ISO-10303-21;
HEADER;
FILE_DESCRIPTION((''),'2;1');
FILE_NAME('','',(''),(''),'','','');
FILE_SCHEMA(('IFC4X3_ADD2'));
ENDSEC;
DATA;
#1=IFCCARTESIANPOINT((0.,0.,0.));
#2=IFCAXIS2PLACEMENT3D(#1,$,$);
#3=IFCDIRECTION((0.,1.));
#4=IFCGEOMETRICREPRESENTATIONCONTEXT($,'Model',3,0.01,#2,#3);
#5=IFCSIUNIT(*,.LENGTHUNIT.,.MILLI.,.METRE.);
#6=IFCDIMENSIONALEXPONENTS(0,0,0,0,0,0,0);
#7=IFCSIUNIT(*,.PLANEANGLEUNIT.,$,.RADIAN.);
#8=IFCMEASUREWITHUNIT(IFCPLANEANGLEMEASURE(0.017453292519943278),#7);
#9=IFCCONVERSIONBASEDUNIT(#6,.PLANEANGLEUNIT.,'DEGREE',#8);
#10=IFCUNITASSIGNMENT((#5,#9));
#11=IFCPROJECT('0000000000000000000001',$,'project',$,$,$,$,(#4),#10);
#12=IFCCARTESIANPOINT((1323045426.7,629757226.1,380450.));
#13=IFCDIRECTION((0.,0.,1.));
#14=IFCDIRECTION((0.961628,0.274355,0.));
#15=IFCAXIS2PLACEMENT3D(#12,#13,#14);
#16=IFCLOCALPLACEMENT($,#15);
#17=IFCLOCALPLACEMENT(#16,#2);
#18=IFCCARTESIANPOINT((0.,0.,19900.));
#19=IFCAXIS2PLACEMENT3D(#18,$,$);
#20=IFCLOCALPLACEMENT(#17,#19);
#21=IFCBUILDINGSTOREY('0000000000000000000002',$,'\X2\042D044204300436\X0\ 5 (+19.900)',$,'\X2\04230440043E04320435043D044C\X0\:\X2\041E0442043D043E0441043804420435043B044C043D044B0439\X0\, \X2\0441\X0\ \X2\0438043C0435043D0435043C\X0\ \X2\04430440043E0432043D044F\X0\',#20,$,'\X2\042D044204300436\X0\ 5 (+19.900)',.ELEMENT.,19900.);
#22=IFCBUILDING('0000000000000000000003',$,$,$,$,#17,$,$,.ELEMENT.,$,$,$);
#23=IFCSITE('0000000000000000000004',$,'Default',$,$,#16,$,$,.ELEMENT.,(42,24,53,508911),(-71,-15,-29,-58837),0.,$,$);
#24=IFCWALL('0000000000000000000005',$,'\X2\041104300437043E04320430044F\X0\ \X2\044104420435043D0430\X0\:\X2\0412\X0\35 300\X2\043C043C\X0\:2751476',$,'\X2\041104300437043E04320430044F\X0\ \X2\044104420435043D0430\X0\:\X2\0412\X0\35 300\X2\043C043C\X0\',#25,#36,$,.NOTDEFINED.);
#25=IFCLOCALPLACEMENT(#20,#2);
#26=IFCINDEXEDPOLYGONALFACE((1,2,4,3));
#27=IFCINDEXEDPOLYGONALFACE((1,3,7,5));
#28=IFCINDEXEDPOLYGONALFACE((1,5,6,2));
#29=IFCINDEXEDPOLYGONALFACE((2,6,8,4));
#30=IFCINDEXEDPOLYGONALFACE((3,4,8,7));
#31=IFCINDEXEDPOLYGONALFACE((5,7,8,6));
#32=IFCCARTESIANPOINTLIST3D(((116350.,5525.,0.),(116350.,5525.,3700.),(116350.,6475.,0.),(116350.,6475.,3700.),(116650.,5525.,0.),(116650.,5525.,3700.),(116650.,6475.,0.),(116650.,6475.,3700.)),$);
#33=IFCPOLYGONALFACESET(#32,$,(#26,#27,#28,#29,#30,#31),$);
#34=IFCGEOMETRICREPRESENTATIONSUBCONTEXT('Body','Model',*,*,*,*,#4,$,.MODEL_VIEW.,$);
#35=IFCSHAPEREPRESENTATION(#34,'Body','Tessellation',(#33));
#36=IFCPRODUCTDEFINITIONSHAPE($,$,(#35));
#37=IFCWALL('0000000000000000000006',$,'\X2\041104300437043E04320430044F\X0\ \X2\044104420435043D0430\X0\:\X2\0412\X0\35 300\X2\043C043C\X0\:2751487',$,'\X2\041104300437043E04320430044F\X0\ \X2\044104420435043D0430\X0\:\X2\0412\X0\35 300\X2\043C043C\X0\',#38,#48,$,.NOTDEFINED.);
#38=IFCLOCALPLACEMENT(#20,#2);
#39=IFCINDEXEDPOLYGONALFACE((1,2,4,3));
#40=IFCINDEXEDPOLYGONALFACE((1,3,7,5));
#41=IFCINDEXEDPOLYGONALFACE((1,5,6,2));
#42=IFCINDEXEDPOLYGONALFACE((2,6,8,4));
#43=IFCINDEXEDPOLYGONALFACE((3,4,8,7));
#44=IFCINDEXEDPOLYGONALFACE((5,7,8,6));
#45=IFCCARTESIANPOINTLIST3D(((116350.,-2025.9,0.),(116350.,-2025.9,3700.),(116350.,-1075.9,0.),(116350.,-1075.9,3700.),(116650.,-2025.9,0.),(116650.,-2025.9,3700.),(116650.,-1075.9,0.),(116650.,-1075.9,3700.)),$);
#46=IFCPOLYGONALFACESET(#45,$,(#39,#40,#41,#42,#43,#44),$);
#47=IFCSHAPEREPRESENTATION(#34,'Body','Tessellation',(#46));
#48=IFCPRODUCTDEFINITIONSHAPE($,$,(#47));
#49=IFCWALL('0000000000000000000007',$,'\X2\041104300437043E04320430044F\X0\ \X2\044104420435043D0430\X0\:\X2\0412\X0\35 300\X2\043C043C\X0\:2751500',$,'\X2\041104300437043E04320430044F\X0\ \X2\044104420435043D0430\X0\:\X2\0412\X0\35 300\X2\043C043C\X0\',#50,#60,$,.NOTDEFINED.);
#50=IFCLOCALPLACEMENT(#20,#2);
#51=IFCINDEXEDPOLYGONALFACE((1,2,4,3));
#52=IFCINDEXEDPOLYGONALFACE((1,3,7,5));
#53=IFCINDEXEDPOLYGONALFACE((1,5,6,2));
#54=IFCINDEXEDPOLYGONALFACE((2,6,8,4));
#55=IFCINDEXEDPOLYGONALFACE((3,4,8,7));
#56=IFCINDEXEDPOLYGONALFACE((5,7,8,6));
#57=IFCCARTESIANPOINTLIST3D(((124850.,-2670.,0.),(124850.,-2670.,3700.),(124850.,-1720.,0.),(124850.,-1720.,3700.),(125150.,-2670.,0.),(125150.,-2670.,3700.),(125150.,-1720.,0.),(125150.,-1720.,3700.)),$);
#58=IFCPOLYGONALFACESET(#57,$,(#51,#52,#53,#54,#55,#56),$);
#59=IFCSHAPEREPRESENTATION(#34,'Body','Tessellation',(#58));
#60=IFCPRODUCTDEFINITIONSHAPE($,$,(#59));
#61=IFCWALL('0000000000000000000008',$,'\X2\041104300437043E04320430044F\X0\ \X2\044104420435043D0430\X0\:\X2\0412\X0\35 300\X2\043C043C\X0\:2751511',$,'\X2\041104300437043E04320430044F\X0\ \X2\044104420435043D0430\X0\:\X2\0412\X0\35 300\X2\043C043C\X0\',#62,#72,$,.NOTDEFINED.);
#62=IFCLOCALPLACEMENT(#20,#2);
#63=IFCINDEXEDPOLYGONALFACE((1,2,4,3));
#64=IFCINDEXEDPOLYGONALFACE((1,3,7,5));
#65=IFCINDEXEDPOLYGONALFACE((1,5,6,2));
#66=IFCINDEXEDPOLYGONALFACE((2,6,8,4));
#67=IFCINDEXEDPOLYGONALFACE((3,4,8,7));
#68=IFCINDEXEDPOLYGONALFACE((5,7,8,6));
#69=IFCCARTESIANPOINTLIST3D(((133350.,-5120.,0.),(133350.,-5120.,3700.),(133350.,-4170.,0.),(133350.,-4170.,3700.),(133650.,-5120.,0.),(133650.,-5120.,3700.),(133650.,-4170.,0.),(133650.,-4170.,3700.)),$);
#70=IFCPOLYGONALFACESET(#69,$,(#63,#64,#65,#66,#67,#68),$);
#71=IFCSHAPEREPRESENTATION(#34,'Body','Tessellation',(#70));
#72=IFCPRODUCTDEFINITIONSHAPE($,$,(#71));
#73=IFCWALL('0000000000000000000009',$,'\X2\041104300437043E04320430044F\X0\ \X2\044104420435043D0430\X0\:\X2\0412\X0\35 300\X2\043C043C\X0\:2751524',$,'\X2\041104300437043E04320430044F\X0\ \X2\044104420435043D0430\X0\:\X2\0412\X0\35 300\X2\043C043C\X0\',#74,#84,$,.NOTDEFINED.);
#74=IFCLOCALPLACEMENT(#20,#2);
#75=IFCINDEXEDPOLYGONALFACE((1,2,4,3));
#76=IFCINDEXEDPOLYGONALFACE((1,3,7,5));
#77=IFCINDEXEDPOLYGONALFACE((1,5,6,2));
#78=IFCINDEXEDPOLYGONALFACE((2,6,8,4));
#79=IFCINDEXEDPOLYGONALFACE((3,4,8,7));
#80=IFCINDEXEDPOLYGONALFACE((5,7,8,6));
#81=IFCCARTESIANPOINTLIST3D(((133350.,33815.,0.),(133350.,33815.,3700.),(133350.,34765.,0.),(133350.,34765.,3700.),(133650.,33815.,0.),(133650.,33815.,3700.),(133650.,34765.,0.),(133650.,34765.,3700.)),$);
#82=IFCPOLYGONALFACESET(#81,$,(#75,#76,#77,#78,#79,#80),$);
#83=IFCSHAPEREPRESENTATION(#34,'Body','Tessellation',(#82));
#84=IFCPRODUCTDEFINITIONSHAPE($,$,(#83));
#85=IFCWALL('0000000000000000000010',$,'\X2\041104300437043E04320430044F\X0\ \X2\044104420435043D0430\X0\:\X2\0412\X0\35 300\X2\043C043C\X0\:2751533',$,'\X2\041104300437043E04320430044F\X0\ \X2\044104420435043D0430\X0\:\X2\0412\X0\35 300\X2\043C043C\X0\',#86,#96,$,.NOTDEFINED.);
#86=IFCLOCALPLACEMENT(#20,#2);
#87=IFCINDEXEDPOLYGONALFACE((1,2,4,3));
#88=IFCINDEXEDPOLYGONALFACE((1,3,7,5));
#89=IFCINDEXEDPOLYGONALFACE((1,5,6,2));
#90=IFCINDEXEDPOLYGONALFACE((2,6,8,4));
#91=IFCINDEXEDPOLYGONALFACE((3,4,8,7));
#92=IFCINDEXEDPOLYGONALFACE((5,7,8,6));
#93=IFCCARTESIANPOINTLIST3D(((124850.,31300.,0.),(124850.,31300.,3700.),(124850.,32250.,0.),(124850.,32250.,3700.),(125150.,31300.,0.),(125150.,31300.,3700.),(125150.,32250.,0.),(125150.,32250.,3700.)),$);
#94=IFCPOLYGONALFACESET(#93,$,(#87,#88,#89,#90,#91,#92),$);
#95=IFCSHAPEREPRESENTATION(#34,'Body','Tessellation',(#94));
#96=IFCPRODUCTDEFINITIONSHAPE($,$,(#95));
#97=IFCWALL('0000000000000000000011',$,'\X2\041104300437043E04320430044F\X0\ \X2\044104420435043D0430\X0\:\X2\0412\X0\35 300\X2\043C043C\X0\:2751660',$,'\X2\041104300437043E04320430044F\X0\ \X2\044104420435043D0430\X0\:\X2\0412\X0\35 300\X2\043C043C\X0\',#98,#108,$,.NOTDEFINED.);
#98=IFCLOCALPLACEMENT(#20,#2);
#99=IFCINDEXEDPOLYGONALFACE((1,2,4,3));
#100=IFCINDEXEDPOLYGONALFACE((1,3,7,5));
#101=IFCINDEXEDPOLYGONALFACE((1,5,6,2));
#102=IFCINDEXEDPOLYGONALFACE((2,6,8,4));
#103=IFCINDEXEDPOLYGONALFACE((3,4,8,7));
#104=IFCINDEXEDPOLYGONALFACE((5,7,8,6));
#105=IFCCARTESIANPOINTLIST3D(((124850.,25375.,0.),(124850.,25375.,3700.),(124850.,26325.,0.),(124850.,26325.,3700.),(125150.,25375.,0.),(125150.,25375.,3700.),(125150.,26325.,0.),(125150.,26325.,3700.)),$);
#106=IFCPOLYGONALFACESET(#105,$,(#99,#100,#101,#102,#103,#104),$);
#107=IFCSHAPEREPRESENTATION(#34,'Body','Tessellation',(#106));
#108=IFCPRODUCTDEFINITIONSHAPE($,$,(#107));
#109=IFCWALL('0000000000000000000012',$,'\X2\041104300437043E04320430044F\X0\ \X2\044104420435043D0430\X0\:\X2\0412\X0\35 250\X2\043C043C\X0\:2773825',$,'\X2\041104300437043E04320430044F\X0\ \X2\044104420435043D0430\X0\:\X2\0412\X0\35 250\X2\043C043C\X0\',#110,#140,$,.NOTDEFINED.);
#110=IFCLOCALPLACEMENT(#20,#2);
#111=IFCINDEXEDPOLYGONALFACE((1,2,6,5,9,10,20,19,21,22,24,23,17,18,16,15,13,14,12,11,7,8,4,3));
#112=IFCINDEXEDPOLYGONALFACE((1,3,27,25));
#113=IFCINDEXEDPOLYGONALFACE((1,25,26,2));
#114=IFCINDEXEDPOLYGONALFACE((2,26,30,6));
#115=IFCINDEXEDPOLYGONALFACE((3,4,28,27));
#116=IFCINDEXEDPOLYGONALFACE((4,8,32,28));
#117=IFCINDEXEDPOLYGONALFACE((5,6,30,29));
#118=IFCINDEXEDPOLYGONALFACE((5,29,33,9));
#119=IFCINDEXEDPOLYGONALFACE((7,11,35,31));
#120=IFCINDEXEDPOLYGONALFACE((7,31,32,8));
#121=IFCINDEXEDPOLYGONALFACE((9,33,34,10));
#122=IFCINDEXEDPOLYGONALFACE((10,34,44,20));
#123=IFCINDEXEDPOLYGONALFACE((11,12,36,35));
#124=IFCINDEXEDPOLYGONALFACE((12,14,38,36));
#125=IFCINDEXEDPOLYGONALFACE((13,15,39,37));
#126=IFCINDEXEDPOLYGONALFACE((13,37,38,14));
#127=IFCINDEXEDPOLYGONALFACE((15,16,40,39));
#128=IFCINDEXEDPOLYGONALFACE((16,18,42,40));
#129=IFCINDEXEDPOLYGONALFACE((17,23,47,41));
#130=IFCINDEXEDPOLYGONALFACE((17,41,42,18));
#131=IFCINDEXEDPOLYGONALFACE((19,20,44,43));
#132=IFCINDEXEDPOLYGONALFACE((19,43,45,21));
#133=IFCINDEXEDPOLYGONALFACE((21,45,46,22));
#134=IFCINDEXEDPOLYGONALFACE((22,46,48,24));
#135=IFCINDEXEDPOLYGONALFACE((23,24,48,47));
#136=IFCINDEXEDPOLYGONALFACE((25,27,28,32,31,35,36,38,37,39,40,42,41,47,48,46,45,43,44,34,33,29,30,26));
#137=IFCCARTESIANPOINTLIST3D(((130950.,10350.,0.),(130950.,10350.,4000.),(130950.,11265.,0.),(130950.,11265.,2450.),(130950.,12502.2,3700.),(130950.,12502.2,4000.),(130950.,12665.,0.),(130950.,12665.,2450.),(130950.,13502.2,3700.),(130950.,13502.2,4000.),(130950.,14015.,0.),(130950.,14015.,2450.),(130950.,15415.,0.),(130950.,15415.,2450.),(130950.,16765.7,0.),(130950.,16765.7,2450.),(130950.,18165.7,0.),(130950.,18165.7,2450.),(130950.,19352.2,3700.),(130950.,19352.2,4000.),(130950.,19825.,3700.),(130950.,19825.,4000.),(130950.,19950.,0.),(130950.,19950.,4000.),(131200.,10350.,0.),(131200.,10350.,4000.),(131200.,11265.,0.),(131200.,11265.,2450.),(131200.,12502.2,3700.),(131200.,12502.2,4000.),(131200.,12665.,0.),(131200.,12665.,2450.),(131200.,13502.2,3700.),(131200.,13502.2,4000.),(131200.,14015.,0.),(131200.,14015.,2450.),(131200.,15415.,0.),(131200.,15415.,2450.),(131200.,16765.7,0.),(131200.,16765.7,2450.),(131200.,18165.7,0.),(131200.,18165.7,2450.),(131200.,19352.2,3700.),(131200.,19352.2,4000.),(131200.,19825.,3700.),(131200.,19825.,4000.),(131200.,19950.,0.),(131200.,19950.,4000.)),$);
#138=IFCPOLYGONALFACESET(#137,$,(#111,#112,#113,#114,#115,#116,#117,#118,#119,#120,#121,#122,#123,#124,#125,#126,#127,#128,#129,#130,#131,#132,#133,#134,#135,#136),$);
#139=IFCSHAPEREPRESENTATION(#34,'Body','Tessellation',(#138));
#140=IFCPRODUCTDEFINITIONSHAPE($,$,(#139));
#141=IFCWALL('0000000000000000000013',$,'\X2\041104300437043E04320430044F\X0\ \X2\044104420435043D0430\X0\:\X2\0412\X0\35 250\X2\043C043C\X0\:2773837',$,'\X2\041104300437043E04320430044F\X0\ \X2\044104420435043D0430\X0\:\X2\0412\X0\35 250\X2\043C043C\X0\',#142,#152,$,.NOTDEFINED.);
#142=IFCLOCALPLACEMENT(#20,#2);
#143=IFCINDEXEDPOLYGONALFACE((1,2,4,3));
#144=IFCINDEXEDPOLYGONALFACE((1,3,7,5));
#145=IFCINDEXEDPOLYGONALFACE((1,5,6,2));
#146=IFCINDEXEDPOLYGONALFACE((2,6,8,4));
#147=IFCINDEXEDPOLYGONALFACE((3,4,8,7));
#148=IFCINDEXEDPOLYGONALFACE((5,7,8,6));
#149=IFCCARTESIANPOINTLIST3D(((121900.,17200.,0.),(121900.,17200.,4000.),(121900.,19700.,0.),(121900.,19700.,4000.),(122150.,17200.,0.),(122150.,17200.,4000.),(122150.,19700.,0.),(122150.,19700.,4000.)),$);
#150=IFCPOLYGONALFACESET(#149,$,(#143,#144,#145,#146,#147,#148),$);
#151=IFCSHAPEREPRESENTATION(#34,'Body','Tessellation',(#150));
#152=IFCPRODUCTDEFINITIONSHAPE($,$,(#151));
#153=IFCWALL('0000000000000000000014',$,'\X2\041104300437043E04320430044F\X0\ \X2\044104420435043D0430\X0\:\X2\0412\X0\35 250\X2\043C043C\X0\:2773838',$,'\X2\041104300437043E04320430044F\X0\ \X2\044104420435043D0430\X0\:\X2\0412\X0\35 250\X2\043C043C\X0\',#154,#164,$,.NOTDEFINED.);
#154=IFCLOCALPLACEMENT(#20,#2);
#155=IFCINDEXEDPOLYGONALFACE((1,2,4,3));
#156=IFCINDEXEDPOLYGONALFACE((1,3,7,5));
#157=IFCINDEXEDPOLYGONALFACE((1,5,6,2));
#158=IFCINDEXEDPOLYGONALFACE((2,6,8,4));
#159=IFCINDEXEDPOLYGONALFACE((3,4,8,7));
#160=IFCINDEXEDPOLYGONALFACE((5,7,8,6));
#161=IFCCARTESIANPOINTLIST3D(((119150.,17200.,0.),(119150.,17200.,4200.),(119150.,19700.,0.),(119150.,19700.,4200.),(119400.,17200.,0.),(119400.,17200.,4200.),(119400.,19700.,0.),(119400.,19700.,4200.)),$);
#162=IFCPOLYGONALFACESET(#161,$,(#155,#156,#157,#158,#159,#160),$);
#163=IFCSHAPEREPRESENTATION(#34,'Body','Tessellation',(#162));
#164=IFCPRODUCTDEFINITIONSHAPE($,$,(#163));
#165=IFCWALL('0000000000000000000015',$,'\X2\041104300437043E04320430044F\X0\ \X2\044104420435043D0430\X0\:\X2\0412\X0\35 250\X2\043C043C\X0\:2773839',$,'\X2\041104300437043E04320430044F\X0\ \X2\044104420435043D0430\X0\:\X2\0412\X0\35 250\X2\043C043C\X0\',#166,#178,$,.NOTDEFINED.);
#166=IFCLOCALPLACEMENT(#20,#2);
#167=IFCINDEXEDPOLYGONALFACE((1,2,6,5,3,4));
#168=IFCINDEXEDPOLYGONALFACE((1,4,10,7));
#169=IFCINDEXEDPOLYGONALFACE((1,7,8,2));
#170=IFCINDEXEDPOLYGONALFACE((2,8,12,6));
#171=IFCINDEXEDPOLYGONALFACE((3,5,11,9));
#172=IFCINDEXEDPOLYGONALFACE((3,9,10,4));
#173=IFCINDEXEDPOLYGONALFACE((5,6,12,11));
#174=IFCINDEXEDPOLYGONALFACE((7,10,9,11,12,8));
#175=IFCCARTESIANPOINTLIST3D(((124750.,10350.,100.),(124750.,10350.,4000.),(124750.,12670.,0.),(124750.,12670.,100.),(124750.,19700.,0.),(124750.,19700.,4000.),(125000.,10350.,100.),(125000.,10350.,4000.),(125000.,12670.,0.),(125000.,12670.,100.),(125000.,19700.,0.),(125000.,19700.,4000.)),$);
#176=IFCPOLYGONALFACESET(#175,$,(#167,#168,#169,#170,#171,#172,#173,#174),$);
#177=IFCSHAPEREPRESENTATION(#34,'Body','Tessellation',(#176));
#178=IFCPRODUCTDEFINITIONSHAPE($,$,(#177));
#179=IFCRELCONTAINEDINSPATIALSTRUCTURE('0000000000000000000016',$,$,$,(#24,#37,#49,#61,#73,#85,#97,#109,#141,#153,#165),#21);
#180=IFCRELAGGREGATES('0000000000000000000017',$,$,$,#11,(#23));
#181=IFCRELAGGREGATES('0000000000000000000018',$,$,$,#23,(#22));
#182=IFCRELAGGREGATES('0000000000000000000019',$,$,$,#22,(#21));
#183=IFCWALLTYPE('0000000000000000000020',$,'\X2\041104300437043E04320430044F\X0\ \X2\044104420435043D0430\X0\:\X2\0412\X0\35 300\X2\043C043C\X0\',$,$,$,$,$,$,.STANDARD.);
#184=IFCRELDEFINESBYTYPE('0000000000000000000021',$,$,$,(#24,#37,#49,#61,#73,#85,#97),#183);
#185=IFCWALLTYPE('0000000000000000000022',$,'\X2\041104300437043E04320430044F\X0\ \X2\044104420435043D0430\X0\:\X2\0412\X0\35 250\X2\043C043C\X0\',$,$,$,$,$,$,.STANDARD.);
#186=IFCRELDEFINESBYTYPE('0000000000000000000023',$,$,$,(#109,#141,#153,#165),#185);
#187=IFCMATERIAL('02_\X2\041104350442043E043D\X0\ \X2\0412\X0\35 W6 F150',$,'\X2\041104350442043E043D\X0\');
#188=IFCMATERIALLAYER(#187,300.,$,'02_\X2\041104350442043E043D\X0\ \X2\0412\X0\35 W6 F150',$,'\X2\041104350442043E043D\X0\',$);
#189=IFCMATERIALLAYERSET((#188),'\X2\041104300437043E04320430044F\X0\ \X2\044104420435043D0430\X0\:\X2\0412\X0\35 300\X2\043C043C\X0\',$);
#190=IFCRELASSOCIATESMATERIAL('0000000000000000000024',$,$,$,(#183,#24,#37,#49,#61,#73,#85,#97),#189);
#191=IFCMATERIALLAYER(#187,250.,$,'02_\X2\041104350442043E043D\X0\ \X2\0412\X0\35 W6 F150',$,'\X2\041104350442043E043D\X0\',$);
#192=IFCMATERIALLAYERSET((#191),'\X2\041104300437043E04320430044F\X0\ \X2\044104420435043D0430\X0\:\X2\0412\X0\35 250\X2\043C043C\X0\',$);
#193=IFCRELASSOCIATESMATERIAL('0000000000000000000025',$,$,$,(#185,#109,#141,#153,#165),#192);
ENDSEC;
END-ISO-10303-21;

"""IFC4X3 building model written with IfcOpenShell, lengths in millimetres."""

from ifc_helpers import new_model, entity, si_unit, converted_unit, direction, frame, frame_2d, origin, place, context, subcontext, project, spatial, rectangle, extrude, material, layer, layer_set, type_object, element, save


model = new_model("IFC4X3")

# Units and contexts
model_context = context("Model", 3, precision=0.01, world=origin(), true_north=direction((0.0, 1.0)))
body_context = subcontext(model_context, "Body", "Model", "MODEL_VIEW")
ifc_project = project(units=[si_unit("LENGTHUNIT", "METRE", prefix="MILLI"), converted_unit("PLANEANGLEUNIT", "DEGREE", entity("IfcPlaneAngleMeasure", 0.017453292519943278), si_unit("PLANEANGLEUNIT", "RADIAN"), dimensions=[0, 0, 0, 0, 0, 0, 0])], contexts=[model_context])

# Site, building, storey
site_placement = place(None, frame((1323045426.7, 629757226.1, 380450.0), z_axis=(0.0, 0.0, 1.0), x_axis=(0.961628, 0.274355, 0.0)))
site = spatial("IfcSite", under=ifc_project, at=site_placement, Name="Default", CompositionType="ELEMENT", RefLatitude=(42, 24, 53, 508911), RefLongitude=(-71, -15, -29, -58837), RefElevation=0.0)
building_placement = place(site_placement, origin())
building = spatial("IfcBuilding", under=site, at=building_placement, CompositionType="ELEMENT")
storey_placement = place(building_placement, frame((0.0, 0.0, 19900.0)))
storey = spatial("IfcBuildingStorey", under=building, at=storey_placement, Name="Этаж 5 (+19.900)", ObjectType="Уровень:Относительный, с именем уровня", LongName="Этаж 5 (+19.900)", CompositionType="ELEMENT", Elevation=19900.0)

# Walls
ifc_material = material(Name="02_Бетон В35 W6 F150", Category="Бетон")
ifc_layer_1 = layer(ifc_material, 300.0, Name="02_Бетон В35 W6 F150", Category="Бетон")
ifc_layer_set_1 = layer_set([ifc_layer_1], Name="Базовая стена:В35 300мм")
wall_type_1 = type_object("IfcWallType", Name="Базовая стена:В35 300мм", PredefinedType="STANDARD", material=ifc_layer_set_1)
for number, where, z_axis, x_axis, name in (
    (1, (116500.0, 5525.0, 0.0), (0.0, 0.0, 1.0), (0.0, 1.0, 0.0), "Базовая стена:В35 300мм:2751476"),
    (2, (116500.0, -2025.9, 0.0), (0.0, 0.0, 1.0), (0.0, 1.0, 0.0), "Базовая стена:В35 300мм:2751487"),
    (3, (125000.0, -2670.0, 0.0), (0.0, 0.0, 1.0), (0.0, 1.0, 0.0), "Базовая стена:В35 300мм:2751500"),
    (4, (133500.0, -5120.0, 0.0), (0.0, 0.0, 1.0), (0.0, 1.0, 0.0), "Базовая стена:В35 300мм:2751511"),
    (5, (133500.0, 33815.0, 0.0), (0.0, 0.0, 1.0), (0.0, 1.0, 0.0), "Базовая стена:В35 300мм:2751524"),
    (6, (125000.0, 31300.0, 0.0), (0.0, 0.0, 1.0), (0.0, 1.0, 0.0), "Базовая стена:В35 300мм:2751533"),
    (7, (125000.0, 25375.0, 0.0), (0.0, 0.0, 1.0), (0.0, 1.0, 0.0), "Базовая стена:В35 300мм:2751660"),
):
    element("IfcWall", number, at=place(storey_placement, frame(where, z_axis=z_axis, x_axis=x_axis)), inside=storey, type_object=wall_type_1, material=ifc_layer_set_1, Name=name, ObjectType="Базовая стена:В35 300мм", PredefinedType="NOTDEFINED", context=body_context, shape_type="SweptSolid", body=[
        extrude(rectangle(XDim=950.0, YDim=300.0, at=frame_2d((475.0, 0.0), x_axis=(-1.0, 0.0))), origin(), (0.0, 0.0, 1.0), 3700.0),
    ])

# Wall, openings
ifc_layer_2 = layer(ifc_material, 250.0, Name="02_Бетон В35 W6 F150", Category="Бетон")
ifc_layer_set_2 = layer_set([ifc_layer_2], Name="Базовая стена:В35 250мм")
wall_type_2 = type_object("IfcWallType", Name="Базовая стена:В35 250мм", PredefinedType="STANDARD", material=ifc_layer_set_2)
wall_1_placement = place(storey_placement, frame((131075.0, 10350.0, 0.0), z_axis=(0.0, 0.0, 1.0), x_axis=(0.0, 1.0, 0.0)))
wall_1 = element("IfcWall", 8, at=wall_1_placement, inside=storey, type_object=wall_type_2, material=ifc_layer_set_2, Name="Базовая стена:В35 250мм:2773825", ObjectType="Базовая стена:В35 250мм", PredefinedType="NOTDEFINED", context=body_context, shape_type="SweptSolid", body=[
    extrude(rectangle(XDim=9600.0, YDim=250.0, at=frame_2d((4800.0, 0.0), x_axis=(-1.0, 0.0))), origin(), (0.0, 0.0, 1.0), 4000.0),
])
opening_1_placement = place(wall_1_placement, origin())
element("IfcOpeningElement", 9, at=opening_1_placement, cuts=wall_1, PredefinedType="OPENING", context=body_context, shape_type="SweptSolid", body=[
    extrude(rectangle(XDim=300.0, YDim=472.8, at=frame_2d((0.0, 0.0), x_axis=(1.0, 0.0))), frame((9238.6, 125.0, 3850.0), z_axis=(0.0, -1.0, 0.0), x_axis=(0.0, 0.0, 1.0)), (0.0, 0.0, 1.0), 250.0),
])
opening_2_placement = place(wall_1_placement, origin())
element("IfcOpeningElement", 10, at=opening_2_placement, cuts=wall_1, PredefinedType="OPENING", context=body_context, shape_type="SweptSolid", body=[
    extrude(rectangle(XDim=300.0, YDim=1000.0, at=frame_2d((0.0, 0.0), x_axis=(0.0, 1.0))), frame((2652.1, 125.0, 3850.0), z_axis=(0.0, -1.0, 0.0), x_axis=(-1.0, 0.0, 0.0)), (0.0, 0.0, 1.0), 250.0),
])
opening_3_placement = place(wall_1_placement, frame((-10350.0, 131075.0, 0.0), z_axis=(0.0, 0.0, 1.0), x_axis=(0.0, -1.0, 0.0)))
element("IfcOpeningElement", 11, at=opening_3_placement, cuts=wall_1, PredefinedType="OPENING", context=body_context, shape_type="SweptSolid", body=[
    extrude(rectangle(XDim=2450.0, YDim=1400.0, at=frame_2d((0.0, 0.0), x_axis=(1.0, 0.0))), frame((132724.0, 11965.0, 1225.0), z_axis=(-1.0, 0.0, 0.0), x_axis=(0.0, 0.0, -1.0)), (0.0, 0.0, 1.0), 3048.0),
])
opening_4_placement = place(wall_1_placement, frame((-10350.0, 131075.0, 0.0), z_axis=(0.0, 0.0, 1.0), x_axis=(0.0, -1.0, 0.0)))
element("IfcOpeningElement", 12, at=opening_4_placement, cuts=wall_1, PredefinedType="OPENING", context=body_context, shape_type="SweptSolid", body=[
    extrude(rectangle(XDim=2450.0, YDim=1400.0, at=frame_2d((0.0, 0.0), x_axis=(1.0, 0.0))), frame((132724.0, 14715.0, 1225.0), z_axis=(-1.0, 0.0, 0.0), x_axis=(0.0, 0.0, -1.0)), (0.0, 0.0, 1.0), 3048.0),
])
opening_5_placement = place(wall_1_placement, frame((-10350.0, 131075.0, 0.0), z_axis=(0.0, 0.0, 1.0), x_axis=(0.0, -1.0, 0.0)))
element("IfcOpeningElement", 13, at=opening_5_placement, cuts=wall_1, PredefinedType="OPENING", context=body_context, shape_type="SweptSolid", body=[
    extrude(rectangle(XDim=2450.0, YDim=1400.0, at=frame_2d((0.0, 0.0), x_axis=(1.0, 0.0))), frame((132724.0, 17465.7, 1225.0), z_axis=(-1.0, 0.0, 0.0), x_axis=(0.0, 0.0, -1.0)), (0.0, 0.0, 1.0), 3048.0),
])

# Walls
wall_2_placement = place(storey_placement, frame((122025.0, 17200.0, 0.0), z_axis=(0.0, 0.0, 1.0), x_axis=(0.0, 1.0, 0.0)))
element("IfcWall", 14, at=wall_2_placement, inside=storey, type_object=wall_type_2, material=ifc_layer_set_2, Name="Базовая стена:В35 250мм:2773837", ObjectType="Базовая стена:В35 250мм", PredefinedType="NOTDEFINED", context=body_context, shape_type="SweptSolid", body=[
    extrude(rectangle(XDim=2500.0, YDim=250.0, at=frame_2d((1250.0, 0.0), x_axis=(-1.0, 0.0))), origin(), (0.0, 0.0, 1.0), 4000.0),
])
wall_3_placement = place(storey_placement, frame((119275.0, 17200.0, 0.0), z_axis=(0.0, 0.0, 1.0), x_axis=(0.0, 1.0, 0.0)))
element("IfcWall", 15, at=wall_3_placement, inside=storey, type_object=wall_type_2, material=ifc_layer_set_2, Name="Базовая стена:В35 250мм:2773838", ObjectType="Базовая стена:В35 250мм", PredefinedType="NOTDEFINED", context=body_context, shape_type="SweptSolid", body=[
    extrude(rectangle(XDim=2500.0, YDim=250.0, at=frame_2d((1250.0, 0.0), x_axis=(-1.0, 0.0))), origin(), (0.0, 0.0, 1.0), 4200.0),
])

# Wall, opening
wall_4_placement = place(storey_placement, frame((124875.0, 19700.0, 0.0), z_axis=(0.0, 0.0, 1.0), x_axis=(0.0, -1.0, 0.0)))
wall_4 = element("IfcWall", 16, at=wall_4_placement, inside=storey, type_object=wall_type_2, material=ifc_layer_set_2, Name="Базовая стена:В35 250мм:2773839", ObjectType="Базовая стена:В35 250мм", PredefinedType="NOTDEFINED", context=body_context, shape_type="SweptSolid", body=[
    extrude(rectangle(XDim=9350.0, YDim=250.0, at=frame_2d((4675.0, 0.0), x_axis=(-1.0, 0.0))), origin(), (0.0, 0.0, 1.0), 4000.0),
])
opening_6_placement = place(wall_4_placement, origin())
element("IfcOpeningElement", 17, at=opening_6_placement, cuts=wall_4, PredefinedType="OPENING", context=body_context, shape_type="SweptSolid", body=[
    extrude(rectangle(XDim=100.0, YDim=2445.0, at=frame_2d((0.0, 0.0), x_axis=(0.0, 1.0))), frame((8252.5, 125.0, 50.0), z_axis=(0.0, -1.0, 0.0), x_axis=(-1.0, 0.0, 0.0)), (0.0, 0.0, 1.0), 250.0),
])

save(model, "model.ifc")
